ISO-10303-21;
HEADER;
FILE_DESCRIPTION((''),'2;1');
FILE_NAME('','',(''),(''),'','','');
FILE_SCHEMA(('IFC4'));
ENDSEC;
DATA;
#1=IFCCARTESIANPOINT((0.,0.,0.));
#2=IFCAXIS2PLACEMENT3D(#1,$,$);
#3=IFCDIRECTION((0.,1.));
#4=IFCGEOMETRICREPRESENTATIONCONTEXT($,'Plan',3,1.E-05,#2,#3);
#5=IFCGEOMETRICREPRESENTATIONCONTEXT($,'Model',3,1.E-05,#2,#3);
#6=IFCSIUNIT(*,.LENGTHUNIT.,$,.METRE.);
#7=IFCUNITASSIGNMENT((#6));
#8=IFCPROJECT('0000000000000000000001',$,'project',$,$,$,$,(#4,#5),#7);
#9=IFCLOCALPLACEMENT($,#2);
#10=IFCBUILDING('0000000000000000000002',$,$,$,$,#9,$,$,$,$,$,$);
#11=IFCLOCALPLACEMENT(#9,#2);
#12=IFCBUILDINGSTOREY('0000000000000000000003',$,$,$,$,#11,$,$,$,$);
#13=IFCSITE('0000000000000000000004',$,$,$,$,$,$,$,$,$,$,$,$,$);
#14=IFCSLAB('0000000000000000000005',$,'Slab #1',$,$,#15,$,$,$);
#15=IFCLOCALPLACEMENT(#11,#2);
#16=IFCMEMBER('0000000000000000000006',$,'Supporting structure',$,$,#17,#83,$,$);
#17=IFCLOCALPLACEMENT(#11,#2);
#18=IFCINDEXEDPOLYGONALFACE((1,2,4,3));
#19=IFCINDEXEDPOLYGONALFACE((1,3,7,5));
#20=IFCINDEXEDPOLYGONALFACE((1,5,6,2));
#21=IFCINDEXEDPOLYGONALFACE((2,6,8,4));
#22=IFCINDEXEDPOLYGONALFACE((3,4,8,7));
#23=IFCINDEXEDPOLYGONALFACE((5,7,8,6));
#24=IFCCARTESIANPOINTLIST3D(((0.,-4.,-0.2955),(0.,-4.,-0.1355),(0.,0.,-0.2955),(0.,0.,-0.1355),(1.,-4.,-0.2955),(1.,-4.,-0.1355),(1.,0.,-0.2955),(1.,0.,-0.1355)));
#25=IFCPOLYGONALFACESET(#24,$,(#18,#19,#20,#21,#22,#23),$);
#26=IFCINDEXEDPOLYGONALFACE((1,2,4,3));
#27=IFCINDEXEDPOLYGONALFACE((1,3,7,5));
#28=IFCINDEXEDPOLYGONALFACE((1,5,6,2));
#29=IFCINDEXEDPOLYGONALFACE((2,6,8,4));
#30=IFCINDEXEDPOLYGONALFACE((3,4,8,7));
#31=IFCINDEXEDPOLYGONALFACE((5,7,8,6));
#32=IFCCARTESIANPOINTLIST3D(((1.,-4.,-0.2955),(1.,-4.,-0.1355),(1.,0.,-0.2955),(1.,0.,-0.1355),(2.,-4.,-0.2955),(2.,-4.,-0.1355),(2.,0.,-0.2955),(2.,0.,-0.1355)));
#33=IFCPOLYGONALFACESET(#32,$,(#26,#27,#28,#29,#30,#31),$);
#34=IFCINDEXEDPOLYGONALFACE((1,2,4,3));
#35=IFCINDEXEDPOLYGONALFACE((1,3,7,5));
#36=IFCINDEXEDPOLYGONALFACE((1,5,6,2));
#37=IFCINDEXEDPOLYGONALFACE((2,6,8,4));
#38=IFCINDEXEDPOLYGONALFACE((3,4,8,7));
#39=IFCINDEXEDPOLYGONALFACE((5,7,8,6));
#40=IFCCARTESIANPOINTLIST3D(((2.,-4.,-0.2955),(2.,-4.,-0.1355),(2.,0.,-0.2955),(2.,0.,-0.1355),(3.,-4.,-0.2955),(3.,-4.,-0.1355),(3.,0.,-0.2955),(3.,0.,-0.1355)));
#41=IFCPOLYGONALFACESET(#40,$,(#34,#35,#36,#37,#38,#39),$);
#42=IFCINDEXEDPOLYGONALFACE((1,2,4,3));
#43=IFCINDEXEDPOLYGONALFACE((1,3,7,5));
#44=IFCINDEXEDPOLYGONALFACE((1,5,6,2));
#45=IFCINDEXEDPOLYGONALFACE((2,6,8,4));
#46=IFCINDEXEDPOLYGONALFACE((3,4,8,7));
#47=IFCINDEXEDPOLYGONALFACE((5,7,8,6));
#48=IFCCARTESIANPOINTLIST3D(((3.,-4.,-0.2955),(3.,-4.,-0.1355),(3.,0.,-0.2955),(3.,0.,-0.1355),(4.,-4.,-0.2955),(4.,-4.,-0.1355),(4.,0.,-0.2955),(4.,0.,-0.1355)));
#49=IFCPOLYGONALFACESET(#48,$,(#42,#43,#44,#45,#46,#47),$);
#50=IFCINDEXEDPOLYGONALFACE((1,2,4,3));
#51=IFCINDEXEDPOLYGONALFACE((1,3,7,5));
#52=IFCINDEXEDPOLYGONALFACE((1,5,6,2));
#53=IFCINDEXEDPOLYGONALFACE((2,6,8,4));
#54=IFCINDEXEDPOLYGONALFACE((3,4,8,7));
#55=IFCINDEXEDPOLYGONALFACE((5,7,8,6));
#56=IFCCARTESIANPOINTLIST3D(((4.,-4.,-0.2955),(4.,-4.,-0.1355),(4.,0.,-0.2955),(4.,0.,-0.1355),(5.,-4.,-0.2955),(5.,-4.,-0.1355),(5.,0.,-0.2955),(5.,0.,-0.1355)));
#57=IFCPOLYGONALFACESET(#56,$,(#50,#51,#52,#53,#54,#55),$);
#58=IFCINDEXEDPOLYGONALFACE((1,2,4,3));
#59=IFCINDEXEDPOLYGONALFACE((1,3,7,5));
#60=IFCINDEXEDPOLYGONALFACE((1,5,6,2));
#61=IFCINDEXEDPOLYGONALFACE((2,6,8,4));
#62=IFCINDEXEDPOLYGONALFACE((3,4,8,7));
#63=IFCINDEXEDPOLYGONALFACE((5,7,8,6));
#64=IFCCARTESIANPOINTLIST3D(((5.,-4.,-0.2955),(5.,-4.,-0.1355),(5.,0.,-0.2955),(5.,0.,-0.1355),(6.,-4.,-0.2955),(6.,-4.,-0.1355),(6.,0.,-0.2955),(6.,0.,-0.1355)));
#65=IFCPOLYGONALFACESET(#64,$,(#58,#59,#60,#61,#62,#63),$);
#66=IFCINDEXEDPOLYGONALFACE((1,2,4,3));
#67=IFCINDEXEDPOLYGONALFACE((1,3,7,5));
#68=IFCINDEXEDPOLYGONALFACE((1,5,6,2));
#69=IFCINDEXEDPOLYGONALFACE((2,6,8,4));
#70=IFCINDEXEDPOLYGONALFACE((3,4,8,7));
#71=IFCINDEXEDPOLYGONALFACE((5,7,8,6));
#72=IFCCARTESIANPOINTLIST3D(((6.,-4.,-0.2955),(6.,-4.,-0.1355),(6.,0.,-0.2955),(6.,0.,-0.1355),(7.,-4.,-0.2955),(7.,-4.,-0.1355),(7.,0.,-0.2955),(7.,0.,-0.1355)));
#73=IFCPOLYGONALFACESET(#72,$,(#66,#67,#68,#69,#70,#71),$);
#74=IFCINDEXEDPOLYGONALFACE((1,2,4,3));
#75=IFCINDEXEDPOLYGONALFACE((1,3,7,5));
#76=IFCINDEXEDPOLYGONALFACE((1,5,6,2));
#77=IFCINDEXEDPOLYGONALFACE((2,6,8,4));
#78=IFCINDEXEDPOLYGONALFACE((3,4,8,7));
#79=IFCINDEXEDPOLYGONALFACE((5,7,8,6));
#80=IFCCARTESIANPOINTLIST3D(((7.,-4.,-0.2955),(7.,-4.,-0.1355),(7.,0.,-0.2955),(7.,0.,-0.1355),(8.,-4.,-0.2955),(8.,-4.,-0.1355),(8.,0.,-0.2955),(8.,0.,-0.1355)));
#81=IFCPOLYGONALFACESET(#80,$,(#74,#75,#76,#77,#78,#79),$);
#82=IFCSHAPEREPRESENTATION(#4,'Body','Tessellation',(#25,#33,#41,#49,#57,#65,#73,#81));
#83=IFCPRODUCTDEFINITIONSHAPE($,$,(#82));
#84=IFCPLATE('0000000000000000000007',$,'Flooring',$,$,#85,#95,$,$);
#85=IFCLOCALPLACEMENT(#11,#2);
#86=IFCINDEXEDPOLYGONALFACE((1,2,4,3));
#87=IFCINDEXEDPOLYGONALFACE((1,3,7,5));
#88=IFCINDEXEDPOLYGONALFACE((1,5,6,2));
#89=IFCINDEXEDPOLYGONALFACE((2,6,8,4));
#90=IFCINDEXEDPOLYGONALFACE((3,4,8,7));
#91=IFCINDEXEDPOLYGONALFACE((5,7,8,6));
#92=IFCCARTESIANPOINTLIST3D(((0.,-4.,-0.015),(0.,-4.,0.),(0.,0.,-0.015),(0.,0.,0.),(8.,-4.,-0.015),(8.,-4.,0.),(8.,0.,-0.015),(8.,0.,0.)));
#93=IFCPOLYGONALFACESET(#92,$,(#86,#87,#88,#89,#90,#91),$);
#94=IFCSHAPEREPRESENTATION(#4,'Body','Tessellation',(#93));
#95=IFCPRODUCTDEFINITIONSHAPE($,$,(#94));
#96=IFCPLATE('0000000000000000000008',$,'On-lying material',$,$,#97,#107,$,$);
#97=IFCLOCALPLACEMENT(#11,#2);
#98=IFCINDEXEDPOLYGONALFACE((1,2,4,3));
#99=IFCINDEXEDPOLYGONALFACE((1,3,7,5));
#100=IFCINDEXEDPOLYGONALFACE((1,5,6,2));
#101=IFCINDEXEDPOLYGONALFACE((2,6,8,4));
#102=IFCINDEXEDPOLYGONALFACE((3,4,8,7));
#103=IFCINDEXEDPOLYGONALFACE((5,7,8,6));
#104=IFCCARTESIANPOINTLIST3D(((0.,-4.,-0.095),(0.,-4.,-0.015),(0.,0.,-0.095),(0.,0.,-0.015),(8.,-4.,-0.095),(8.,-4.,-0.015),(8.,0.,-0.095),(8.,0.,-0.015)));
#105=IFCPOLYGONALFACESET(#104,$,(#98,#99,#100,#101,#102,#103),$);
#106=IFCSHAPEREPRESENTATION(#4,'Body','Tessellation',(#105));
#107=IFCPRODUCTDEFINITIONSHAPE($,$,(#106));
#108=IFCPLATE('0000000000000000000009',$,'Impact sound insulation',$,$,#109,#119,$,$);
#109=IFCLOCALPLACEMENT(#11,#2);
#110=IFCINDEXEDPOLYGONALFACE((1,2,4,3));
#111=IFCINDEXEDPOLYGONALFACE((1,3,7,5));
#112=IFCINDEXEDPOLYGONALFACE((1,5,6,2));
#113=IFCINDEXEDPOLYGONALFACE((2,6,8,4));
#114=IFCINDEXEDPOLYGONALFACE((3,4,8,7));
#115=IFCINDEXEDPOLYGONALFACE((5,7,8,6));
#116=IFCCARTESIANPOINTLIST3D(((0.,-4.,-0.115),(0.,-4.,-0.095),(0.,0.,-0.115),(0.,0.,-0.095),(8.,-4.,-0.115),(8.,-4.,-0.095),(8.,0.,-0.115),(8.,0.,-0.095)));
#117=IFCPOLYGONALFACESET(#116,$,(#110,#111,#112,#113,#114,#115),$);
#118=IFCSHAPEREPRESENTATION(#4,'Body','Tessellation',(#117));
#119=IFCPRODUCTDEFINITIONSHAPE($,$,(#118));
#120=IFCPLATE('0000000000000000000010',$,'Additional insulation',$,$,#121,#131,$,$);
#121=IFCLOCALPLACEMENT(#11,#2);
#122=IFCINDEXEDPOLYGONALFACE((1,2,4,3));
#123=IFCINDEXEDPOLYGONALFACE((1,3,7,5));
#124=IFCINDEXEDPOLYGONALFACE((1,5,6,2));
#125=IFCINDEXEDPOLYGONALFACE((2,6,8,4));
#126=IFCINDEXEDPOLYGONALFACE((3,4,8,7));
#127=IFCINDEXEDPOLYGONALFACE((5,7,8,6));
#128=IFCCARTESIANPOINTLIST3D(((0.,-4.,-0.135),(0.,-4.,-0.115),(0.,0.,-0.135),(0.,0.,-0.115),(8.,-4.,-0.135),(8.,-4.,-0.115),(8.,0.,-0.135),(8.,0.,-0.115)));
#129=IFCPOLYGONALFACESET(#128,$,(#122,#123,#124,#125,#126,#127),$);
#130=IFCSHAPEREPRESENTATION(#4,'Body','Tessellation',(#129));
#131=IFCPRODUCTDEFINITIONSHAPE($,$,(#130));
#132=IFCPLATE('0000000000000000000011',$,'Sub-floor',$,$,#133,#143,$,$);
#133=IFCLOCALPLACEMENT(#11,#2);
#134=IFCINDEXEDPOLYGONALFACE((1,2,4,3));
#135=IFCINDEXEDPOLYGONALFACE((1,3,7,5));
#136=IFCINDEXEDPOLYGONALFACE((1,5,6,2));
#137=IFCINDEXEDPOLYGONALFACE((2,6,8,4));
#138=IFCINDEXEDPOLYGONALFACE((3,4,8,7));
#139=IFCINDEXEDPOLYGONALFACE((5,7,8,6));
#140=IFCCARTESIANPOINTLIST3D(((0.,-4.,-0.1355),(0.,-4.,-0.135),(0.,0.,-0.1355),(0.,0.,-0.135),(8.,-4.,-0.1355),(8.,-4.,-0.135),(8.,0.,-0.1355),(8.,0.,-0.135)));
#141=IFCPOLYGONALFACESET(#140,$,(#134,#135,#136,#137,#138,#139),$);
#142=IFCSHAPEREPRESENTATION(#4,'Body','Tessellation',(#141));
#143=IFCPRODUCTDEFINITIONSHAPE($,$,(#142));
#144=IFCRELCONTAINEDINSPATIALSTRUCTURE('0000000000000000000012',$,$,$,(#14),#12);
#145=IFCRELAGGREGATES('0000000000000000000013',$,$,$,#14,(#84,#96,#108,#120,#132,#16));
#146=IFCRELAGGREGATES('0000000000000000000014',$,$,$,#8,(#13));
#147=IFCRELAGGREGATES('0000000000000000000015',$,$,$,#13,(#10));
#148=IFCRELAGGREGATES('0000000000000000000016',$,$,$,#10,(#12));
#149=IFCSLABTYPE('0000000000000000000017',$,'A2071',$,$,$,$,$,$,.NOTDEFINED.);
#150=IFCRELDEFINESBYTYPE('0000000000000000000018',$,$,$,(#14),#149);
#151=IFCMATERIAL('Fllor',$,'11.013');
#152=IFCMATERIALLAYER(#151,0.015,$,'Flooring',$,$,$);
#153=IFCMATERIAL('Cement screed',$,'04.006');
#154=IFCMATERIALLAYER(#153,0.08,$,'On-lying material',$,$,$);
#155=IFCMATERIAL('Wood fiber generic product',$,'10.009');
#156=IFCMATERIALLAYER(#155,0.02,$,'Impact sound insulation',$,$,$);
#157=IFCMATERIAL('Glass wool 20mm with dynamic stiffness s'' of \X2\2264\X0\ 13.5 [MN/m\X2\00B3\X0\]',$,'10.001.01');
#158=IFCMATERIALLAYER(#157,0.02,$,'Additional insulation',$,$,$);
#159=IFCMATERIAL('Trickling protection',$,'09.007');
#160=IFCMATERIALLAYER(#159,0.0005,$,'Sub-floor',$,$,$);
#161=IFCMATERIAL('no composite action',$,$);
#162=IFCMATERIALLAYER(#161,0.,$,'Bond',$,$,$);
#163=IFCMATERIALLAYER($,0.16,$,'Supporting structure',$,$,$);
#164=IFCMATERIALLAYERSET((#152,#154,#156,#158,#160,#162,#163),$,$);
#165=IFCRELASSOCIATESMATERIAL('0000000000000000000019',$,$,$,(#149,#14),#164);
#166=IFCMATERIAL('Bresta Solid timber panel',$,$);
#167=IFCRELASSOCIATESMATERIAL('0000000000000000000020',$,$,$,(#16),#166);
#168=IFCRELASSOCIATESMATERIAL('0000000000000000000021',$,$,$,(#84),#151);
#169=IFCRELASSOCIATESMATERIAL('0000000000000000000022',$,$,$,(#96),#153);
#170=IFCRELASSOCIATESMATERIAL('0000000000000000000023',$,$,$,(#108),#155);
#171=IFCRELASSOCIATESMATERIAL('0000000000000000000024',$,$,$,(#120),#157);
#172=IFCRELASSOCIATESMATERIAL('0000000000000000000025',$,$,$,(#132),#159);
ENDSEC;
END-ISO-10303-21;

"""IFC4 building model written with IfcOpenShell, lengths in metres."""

from ifc_helpers import new_model, si_unit, direction, frame, frame_2d, origin, origin_with_axes, place, context, project, spatial, rectangle, extrude, material, layer, layer_set, type_object, element, aggregate, save


model = new_model("IFC4")

# Units and contexts
plan_context = context("Plan", 3, precision=1e-05, world=origin(), true_north=direction((0.0, 1.0)))
model_context = context("Model", 3, precision=1e-05, world=origin(), true_north=direction((0.0, 1.0)))
ifc_project = project(units=[si_unit("LENGTHUNIT", "METRE")], contexts=[plan_context, model_context])

# Site, building, storey
site = spatial("IfcSite", under=ifc_project)
building_placement = place(None, origin())
building = spatial("IfcBuilding", under=site, at=building_placement)
storey_placement = place(building_placement, origin())
storey = spatial("IfcBuildingStorey", under=building, at=storey_placement)

# Slab, member, plates
ifc_material_1 = material(Name="Fllor", Category="11.013")
ifc_layer_1 = layer(ifc_material_1, 0.015, Name="Flooring")
ifc_material_2 = material(Name="Cement screed", Category="04.006")
ifc_layer_2 = layer(ifc_material_2, 0.08, Name="On-lying material")
ifc_material_3 = material(Name="Wood fiber generic product", Category="10.009")
ifc_layer_3 = layer(ifc_material_3, 0.02, Name="Impact sound insulation")
ifc_material_4 = material(Name="Glass wool 20mm with dynamic stiffness s' of ≤ 13.5 [MN/m³]", Category="10.001.01")
ifc_layer_4 = layer(ifc_material_4, 0.02, Name="Additional insulation")
ifc_material_5 = material(Name="Trickling protection", Category="09.007")
ifc_layer_5 = layer(ifc_material_5, 0.0005, Name="Sub-floor")
ifc_material_6 = material(Name="no composite action")
ifc_layer_6 = layer(ifc_material_6, 0.0, Name="Bond")
ifc_layer_7 = layer(None, 0.16, Name="Supporting structure")
ifc_layer_set = layer_set([ifc_layer_1, ifc_layer_2, ifc_layer_3, ifc_layer_4, ifc_layer_5, ifc_layer_6, ifc_layer_7])
slab_type = type_object("IfcSlabType", Name="A2071", PredefinedType="NOTDEFINED", material=ifc_layer_set)
slab_placement = place(None, frame((0.0, 0.0, 0.0), z_axis=(0.0, 0.0, -1.0), x_axis=(1.0, 0.0, 0.0)))
slab = element("IfcSlab", 1, at=slab_placement, inside=storey, type_object=slab_type, material=ifc_layer_set, Name="Slab #1")
ifc_material_7 = material(Name="Bresta Solid timber panel")
member_placement = place(slab_placement, origin())
member = element("IfcMember", 2, at=member_placement, material=ifc_material_7, Name="Supporting structure", context=plan_context, shape_type="SweptSolid", body=[
    extrude(rectangle(XDim=1.0, YDim=0.16, at=frame_2d((0.5, 0.08), x_axis=(1.0, 0.0))), frame((0.0, 4.0, 0.1355), z_axis=(0.0, -1.0, 0.0), x_axis=(1.0, 0.0, 0.0)), (0.0, 0.0, 1.0), 4.0),
    extrude(rectangle(XDim=1.0, YDim=0.16, at=frame_2d((0.5, 0.08), x_axis=(1.0, 0.0))), frame((1.0, 4.0, 0.1355), z_axis=(0.0, -1.0, 0.0), x_axis=(1.0, 0.0, 0.0)), (0.0, 0.0, 1.0), 4.0),
    extrude(rectangle(XDim=1.0, YDim=0.16, at=frame_2d((0.5, 0.08), x_axis=(1.0, 0.0))), frame((2.0, 4.0, 0.1355), z_axis=(0.0, -1.0, 0.0), x_axis=(1.0, 0.0, 0.0)), (0.0, 0.0, 1.0), 4.0),
    extrude(rectangle(XDim=1.0, YDim=0.16, at=frame_2d((0.5, 0.08), x_axis=(1.0, 0.0))), frame((3.0, 4.0, 0.1355), z_axis=(0.0, -1.0, 0.0), x_axis=(1.0, 0.0, 0.0)), (0.0, 0.0, 1.0), 4.0),
    extrude(rectangle(XDim=1.0, YDim=0.16, at=frame_2d((0.5, 0.08), x_axis=(1.0, 0.0))), frame((4.0, 4.0, 0.1355), z_axis=(0.0, -1.0, 0.0), x_axis=(1.0, 0.0, 0.0)), (0.0, 0.0, 1.0), 4.0),
    extrude(rectangle(XDim=1.0, YDim=0.16, at=frame_2d((0.5, 0.08), x_axis=(1.0, 0.0))), frame((5.0, 4.0, 0.1355), z_axis=(0.0, -1.0, 0.0), x_axis=(1.0, 0.0, 0.0)), (0.0, 0.0, 1.0), 4.0),
    extrude(rectangle(XDim=1.0, YDim=0.16, at=frame_2d((0.5, 0.08), x_axis=(1.0, 0.0))), frame((6.0, 4.0, 0.1355), z_axis=(0.0, -1.0, 0.0), x_axis=(1.0, 0.0, 0.0)), (0.0, 0.0, 1.0), 4.0),
    extrude(rectangle(XDim=1.0, YDim=0.16, at=frame_2d((0.5, 0.08), x_axis=(1.0, 0.0))), frame((7.0, 4.0, 0.1355), z_axis=(0.0, -1.0, 0.0), x_axis=(1.0, 0.0, 0.0)), (0.0, 0.0, 1.0), 4.0),
])
plate_1_placement = place(slab_placement, origin())
plate_1 = element("IfcPlate", 3, at=plate_1_placement, material=ifc_material_1, Name="Flooring", context=plan_context, shape_type="SweptSolid", body=[
    extrude(rectangle(XDim=8.0, YDim=4.0, at=frame_2d((4.0, 2.0), x_axis=(1.0, 0.0))), origin_with_axes(), (0.0, 0.0, 1.0), 0.015),
])
plate_2_placement = place(slab_placement, origin())
plate_2 = element("IfcPlate", 4, at=plate_2_placement, material=ifc_material_2, Name="On-lying material", context=plan_context, shape_type="SweptSolid", body=[
    extrude(rectangle(XDim=8.0, YDim=4.0, at=frame_2d((4.0, 2.0), x_axis=(1.0, 0.0))), frame((0.0, 0.0, 0.015), z_axis=(0.0, 0.0, 1.0), x_axis=(1.0, 0.0, 0.0)), (0.0, 0.0, 1.0), 0.08),
])
plate_3_placement = place(slab_placement, origin())
plate_3 = element("IfcPlate", 5, at=plate_3_placement, material=ifc_material_3, Name="Impact sound insulation", context=plan_context, shape_type="SweptSolid", body=[
    extrude(rectangle(XDim=8.0, YDim=4.0, at=frame_2d((4.0, 2.0), x_axis=(1.0, 0.0))), frame((0.0, 0.0, 0.095), z_axis=(0.0, 0.0, 1.0), x_axis=(1.0, 0.0, 0.0)), (0.0, 0.0, 1.0), 0.02),
])
plate_4_placement = place(slab_placement, origin())
plate_4 = element("IfcPlate", 6, at=plate_4_placement, material=ifc_material_4, Name="Additional insulation", context=plan_context, shape_type="SweptSolid", body=[
    extrude(rectangle(XDim=8.0, YDim=4.0, at=frame_2d((4.0, 2.0), x_axis=(1.0, 0.0))), frame((0.0, 0.0, 0.115), z_axis=(0.0, 0.0, 1.0), x_axis=(1.0, 0.0, 0.0)), (0.0, 0.0, 1.0), 0.02),
])
plate_5_placement = place(slab_placement, origin())
plate_5 = element("IfcPlate", 7, at=plate_5_placement, material=ifc_material_5, Name="Sub-floor", context=plan_context, shape_type="SweptSolid", body=[
    extrude(rectangle(XDim=8.0, YDim=4.0, at=frame_2d((4.0, 2.0), x_axis=(1.0, 0.0))), frame((0.0, 0.0, 0.135), z_axis=(0.0, 0.0, 1.0), x_axis=(1.0, 0.0, 0.0)), (0.0, 0.0, 1.0), 0.0005),
])
aggregate(slab, [plate_1, plate_2, plate_3, plate_4, plate_5, member])

save(model, "model.ifc")
